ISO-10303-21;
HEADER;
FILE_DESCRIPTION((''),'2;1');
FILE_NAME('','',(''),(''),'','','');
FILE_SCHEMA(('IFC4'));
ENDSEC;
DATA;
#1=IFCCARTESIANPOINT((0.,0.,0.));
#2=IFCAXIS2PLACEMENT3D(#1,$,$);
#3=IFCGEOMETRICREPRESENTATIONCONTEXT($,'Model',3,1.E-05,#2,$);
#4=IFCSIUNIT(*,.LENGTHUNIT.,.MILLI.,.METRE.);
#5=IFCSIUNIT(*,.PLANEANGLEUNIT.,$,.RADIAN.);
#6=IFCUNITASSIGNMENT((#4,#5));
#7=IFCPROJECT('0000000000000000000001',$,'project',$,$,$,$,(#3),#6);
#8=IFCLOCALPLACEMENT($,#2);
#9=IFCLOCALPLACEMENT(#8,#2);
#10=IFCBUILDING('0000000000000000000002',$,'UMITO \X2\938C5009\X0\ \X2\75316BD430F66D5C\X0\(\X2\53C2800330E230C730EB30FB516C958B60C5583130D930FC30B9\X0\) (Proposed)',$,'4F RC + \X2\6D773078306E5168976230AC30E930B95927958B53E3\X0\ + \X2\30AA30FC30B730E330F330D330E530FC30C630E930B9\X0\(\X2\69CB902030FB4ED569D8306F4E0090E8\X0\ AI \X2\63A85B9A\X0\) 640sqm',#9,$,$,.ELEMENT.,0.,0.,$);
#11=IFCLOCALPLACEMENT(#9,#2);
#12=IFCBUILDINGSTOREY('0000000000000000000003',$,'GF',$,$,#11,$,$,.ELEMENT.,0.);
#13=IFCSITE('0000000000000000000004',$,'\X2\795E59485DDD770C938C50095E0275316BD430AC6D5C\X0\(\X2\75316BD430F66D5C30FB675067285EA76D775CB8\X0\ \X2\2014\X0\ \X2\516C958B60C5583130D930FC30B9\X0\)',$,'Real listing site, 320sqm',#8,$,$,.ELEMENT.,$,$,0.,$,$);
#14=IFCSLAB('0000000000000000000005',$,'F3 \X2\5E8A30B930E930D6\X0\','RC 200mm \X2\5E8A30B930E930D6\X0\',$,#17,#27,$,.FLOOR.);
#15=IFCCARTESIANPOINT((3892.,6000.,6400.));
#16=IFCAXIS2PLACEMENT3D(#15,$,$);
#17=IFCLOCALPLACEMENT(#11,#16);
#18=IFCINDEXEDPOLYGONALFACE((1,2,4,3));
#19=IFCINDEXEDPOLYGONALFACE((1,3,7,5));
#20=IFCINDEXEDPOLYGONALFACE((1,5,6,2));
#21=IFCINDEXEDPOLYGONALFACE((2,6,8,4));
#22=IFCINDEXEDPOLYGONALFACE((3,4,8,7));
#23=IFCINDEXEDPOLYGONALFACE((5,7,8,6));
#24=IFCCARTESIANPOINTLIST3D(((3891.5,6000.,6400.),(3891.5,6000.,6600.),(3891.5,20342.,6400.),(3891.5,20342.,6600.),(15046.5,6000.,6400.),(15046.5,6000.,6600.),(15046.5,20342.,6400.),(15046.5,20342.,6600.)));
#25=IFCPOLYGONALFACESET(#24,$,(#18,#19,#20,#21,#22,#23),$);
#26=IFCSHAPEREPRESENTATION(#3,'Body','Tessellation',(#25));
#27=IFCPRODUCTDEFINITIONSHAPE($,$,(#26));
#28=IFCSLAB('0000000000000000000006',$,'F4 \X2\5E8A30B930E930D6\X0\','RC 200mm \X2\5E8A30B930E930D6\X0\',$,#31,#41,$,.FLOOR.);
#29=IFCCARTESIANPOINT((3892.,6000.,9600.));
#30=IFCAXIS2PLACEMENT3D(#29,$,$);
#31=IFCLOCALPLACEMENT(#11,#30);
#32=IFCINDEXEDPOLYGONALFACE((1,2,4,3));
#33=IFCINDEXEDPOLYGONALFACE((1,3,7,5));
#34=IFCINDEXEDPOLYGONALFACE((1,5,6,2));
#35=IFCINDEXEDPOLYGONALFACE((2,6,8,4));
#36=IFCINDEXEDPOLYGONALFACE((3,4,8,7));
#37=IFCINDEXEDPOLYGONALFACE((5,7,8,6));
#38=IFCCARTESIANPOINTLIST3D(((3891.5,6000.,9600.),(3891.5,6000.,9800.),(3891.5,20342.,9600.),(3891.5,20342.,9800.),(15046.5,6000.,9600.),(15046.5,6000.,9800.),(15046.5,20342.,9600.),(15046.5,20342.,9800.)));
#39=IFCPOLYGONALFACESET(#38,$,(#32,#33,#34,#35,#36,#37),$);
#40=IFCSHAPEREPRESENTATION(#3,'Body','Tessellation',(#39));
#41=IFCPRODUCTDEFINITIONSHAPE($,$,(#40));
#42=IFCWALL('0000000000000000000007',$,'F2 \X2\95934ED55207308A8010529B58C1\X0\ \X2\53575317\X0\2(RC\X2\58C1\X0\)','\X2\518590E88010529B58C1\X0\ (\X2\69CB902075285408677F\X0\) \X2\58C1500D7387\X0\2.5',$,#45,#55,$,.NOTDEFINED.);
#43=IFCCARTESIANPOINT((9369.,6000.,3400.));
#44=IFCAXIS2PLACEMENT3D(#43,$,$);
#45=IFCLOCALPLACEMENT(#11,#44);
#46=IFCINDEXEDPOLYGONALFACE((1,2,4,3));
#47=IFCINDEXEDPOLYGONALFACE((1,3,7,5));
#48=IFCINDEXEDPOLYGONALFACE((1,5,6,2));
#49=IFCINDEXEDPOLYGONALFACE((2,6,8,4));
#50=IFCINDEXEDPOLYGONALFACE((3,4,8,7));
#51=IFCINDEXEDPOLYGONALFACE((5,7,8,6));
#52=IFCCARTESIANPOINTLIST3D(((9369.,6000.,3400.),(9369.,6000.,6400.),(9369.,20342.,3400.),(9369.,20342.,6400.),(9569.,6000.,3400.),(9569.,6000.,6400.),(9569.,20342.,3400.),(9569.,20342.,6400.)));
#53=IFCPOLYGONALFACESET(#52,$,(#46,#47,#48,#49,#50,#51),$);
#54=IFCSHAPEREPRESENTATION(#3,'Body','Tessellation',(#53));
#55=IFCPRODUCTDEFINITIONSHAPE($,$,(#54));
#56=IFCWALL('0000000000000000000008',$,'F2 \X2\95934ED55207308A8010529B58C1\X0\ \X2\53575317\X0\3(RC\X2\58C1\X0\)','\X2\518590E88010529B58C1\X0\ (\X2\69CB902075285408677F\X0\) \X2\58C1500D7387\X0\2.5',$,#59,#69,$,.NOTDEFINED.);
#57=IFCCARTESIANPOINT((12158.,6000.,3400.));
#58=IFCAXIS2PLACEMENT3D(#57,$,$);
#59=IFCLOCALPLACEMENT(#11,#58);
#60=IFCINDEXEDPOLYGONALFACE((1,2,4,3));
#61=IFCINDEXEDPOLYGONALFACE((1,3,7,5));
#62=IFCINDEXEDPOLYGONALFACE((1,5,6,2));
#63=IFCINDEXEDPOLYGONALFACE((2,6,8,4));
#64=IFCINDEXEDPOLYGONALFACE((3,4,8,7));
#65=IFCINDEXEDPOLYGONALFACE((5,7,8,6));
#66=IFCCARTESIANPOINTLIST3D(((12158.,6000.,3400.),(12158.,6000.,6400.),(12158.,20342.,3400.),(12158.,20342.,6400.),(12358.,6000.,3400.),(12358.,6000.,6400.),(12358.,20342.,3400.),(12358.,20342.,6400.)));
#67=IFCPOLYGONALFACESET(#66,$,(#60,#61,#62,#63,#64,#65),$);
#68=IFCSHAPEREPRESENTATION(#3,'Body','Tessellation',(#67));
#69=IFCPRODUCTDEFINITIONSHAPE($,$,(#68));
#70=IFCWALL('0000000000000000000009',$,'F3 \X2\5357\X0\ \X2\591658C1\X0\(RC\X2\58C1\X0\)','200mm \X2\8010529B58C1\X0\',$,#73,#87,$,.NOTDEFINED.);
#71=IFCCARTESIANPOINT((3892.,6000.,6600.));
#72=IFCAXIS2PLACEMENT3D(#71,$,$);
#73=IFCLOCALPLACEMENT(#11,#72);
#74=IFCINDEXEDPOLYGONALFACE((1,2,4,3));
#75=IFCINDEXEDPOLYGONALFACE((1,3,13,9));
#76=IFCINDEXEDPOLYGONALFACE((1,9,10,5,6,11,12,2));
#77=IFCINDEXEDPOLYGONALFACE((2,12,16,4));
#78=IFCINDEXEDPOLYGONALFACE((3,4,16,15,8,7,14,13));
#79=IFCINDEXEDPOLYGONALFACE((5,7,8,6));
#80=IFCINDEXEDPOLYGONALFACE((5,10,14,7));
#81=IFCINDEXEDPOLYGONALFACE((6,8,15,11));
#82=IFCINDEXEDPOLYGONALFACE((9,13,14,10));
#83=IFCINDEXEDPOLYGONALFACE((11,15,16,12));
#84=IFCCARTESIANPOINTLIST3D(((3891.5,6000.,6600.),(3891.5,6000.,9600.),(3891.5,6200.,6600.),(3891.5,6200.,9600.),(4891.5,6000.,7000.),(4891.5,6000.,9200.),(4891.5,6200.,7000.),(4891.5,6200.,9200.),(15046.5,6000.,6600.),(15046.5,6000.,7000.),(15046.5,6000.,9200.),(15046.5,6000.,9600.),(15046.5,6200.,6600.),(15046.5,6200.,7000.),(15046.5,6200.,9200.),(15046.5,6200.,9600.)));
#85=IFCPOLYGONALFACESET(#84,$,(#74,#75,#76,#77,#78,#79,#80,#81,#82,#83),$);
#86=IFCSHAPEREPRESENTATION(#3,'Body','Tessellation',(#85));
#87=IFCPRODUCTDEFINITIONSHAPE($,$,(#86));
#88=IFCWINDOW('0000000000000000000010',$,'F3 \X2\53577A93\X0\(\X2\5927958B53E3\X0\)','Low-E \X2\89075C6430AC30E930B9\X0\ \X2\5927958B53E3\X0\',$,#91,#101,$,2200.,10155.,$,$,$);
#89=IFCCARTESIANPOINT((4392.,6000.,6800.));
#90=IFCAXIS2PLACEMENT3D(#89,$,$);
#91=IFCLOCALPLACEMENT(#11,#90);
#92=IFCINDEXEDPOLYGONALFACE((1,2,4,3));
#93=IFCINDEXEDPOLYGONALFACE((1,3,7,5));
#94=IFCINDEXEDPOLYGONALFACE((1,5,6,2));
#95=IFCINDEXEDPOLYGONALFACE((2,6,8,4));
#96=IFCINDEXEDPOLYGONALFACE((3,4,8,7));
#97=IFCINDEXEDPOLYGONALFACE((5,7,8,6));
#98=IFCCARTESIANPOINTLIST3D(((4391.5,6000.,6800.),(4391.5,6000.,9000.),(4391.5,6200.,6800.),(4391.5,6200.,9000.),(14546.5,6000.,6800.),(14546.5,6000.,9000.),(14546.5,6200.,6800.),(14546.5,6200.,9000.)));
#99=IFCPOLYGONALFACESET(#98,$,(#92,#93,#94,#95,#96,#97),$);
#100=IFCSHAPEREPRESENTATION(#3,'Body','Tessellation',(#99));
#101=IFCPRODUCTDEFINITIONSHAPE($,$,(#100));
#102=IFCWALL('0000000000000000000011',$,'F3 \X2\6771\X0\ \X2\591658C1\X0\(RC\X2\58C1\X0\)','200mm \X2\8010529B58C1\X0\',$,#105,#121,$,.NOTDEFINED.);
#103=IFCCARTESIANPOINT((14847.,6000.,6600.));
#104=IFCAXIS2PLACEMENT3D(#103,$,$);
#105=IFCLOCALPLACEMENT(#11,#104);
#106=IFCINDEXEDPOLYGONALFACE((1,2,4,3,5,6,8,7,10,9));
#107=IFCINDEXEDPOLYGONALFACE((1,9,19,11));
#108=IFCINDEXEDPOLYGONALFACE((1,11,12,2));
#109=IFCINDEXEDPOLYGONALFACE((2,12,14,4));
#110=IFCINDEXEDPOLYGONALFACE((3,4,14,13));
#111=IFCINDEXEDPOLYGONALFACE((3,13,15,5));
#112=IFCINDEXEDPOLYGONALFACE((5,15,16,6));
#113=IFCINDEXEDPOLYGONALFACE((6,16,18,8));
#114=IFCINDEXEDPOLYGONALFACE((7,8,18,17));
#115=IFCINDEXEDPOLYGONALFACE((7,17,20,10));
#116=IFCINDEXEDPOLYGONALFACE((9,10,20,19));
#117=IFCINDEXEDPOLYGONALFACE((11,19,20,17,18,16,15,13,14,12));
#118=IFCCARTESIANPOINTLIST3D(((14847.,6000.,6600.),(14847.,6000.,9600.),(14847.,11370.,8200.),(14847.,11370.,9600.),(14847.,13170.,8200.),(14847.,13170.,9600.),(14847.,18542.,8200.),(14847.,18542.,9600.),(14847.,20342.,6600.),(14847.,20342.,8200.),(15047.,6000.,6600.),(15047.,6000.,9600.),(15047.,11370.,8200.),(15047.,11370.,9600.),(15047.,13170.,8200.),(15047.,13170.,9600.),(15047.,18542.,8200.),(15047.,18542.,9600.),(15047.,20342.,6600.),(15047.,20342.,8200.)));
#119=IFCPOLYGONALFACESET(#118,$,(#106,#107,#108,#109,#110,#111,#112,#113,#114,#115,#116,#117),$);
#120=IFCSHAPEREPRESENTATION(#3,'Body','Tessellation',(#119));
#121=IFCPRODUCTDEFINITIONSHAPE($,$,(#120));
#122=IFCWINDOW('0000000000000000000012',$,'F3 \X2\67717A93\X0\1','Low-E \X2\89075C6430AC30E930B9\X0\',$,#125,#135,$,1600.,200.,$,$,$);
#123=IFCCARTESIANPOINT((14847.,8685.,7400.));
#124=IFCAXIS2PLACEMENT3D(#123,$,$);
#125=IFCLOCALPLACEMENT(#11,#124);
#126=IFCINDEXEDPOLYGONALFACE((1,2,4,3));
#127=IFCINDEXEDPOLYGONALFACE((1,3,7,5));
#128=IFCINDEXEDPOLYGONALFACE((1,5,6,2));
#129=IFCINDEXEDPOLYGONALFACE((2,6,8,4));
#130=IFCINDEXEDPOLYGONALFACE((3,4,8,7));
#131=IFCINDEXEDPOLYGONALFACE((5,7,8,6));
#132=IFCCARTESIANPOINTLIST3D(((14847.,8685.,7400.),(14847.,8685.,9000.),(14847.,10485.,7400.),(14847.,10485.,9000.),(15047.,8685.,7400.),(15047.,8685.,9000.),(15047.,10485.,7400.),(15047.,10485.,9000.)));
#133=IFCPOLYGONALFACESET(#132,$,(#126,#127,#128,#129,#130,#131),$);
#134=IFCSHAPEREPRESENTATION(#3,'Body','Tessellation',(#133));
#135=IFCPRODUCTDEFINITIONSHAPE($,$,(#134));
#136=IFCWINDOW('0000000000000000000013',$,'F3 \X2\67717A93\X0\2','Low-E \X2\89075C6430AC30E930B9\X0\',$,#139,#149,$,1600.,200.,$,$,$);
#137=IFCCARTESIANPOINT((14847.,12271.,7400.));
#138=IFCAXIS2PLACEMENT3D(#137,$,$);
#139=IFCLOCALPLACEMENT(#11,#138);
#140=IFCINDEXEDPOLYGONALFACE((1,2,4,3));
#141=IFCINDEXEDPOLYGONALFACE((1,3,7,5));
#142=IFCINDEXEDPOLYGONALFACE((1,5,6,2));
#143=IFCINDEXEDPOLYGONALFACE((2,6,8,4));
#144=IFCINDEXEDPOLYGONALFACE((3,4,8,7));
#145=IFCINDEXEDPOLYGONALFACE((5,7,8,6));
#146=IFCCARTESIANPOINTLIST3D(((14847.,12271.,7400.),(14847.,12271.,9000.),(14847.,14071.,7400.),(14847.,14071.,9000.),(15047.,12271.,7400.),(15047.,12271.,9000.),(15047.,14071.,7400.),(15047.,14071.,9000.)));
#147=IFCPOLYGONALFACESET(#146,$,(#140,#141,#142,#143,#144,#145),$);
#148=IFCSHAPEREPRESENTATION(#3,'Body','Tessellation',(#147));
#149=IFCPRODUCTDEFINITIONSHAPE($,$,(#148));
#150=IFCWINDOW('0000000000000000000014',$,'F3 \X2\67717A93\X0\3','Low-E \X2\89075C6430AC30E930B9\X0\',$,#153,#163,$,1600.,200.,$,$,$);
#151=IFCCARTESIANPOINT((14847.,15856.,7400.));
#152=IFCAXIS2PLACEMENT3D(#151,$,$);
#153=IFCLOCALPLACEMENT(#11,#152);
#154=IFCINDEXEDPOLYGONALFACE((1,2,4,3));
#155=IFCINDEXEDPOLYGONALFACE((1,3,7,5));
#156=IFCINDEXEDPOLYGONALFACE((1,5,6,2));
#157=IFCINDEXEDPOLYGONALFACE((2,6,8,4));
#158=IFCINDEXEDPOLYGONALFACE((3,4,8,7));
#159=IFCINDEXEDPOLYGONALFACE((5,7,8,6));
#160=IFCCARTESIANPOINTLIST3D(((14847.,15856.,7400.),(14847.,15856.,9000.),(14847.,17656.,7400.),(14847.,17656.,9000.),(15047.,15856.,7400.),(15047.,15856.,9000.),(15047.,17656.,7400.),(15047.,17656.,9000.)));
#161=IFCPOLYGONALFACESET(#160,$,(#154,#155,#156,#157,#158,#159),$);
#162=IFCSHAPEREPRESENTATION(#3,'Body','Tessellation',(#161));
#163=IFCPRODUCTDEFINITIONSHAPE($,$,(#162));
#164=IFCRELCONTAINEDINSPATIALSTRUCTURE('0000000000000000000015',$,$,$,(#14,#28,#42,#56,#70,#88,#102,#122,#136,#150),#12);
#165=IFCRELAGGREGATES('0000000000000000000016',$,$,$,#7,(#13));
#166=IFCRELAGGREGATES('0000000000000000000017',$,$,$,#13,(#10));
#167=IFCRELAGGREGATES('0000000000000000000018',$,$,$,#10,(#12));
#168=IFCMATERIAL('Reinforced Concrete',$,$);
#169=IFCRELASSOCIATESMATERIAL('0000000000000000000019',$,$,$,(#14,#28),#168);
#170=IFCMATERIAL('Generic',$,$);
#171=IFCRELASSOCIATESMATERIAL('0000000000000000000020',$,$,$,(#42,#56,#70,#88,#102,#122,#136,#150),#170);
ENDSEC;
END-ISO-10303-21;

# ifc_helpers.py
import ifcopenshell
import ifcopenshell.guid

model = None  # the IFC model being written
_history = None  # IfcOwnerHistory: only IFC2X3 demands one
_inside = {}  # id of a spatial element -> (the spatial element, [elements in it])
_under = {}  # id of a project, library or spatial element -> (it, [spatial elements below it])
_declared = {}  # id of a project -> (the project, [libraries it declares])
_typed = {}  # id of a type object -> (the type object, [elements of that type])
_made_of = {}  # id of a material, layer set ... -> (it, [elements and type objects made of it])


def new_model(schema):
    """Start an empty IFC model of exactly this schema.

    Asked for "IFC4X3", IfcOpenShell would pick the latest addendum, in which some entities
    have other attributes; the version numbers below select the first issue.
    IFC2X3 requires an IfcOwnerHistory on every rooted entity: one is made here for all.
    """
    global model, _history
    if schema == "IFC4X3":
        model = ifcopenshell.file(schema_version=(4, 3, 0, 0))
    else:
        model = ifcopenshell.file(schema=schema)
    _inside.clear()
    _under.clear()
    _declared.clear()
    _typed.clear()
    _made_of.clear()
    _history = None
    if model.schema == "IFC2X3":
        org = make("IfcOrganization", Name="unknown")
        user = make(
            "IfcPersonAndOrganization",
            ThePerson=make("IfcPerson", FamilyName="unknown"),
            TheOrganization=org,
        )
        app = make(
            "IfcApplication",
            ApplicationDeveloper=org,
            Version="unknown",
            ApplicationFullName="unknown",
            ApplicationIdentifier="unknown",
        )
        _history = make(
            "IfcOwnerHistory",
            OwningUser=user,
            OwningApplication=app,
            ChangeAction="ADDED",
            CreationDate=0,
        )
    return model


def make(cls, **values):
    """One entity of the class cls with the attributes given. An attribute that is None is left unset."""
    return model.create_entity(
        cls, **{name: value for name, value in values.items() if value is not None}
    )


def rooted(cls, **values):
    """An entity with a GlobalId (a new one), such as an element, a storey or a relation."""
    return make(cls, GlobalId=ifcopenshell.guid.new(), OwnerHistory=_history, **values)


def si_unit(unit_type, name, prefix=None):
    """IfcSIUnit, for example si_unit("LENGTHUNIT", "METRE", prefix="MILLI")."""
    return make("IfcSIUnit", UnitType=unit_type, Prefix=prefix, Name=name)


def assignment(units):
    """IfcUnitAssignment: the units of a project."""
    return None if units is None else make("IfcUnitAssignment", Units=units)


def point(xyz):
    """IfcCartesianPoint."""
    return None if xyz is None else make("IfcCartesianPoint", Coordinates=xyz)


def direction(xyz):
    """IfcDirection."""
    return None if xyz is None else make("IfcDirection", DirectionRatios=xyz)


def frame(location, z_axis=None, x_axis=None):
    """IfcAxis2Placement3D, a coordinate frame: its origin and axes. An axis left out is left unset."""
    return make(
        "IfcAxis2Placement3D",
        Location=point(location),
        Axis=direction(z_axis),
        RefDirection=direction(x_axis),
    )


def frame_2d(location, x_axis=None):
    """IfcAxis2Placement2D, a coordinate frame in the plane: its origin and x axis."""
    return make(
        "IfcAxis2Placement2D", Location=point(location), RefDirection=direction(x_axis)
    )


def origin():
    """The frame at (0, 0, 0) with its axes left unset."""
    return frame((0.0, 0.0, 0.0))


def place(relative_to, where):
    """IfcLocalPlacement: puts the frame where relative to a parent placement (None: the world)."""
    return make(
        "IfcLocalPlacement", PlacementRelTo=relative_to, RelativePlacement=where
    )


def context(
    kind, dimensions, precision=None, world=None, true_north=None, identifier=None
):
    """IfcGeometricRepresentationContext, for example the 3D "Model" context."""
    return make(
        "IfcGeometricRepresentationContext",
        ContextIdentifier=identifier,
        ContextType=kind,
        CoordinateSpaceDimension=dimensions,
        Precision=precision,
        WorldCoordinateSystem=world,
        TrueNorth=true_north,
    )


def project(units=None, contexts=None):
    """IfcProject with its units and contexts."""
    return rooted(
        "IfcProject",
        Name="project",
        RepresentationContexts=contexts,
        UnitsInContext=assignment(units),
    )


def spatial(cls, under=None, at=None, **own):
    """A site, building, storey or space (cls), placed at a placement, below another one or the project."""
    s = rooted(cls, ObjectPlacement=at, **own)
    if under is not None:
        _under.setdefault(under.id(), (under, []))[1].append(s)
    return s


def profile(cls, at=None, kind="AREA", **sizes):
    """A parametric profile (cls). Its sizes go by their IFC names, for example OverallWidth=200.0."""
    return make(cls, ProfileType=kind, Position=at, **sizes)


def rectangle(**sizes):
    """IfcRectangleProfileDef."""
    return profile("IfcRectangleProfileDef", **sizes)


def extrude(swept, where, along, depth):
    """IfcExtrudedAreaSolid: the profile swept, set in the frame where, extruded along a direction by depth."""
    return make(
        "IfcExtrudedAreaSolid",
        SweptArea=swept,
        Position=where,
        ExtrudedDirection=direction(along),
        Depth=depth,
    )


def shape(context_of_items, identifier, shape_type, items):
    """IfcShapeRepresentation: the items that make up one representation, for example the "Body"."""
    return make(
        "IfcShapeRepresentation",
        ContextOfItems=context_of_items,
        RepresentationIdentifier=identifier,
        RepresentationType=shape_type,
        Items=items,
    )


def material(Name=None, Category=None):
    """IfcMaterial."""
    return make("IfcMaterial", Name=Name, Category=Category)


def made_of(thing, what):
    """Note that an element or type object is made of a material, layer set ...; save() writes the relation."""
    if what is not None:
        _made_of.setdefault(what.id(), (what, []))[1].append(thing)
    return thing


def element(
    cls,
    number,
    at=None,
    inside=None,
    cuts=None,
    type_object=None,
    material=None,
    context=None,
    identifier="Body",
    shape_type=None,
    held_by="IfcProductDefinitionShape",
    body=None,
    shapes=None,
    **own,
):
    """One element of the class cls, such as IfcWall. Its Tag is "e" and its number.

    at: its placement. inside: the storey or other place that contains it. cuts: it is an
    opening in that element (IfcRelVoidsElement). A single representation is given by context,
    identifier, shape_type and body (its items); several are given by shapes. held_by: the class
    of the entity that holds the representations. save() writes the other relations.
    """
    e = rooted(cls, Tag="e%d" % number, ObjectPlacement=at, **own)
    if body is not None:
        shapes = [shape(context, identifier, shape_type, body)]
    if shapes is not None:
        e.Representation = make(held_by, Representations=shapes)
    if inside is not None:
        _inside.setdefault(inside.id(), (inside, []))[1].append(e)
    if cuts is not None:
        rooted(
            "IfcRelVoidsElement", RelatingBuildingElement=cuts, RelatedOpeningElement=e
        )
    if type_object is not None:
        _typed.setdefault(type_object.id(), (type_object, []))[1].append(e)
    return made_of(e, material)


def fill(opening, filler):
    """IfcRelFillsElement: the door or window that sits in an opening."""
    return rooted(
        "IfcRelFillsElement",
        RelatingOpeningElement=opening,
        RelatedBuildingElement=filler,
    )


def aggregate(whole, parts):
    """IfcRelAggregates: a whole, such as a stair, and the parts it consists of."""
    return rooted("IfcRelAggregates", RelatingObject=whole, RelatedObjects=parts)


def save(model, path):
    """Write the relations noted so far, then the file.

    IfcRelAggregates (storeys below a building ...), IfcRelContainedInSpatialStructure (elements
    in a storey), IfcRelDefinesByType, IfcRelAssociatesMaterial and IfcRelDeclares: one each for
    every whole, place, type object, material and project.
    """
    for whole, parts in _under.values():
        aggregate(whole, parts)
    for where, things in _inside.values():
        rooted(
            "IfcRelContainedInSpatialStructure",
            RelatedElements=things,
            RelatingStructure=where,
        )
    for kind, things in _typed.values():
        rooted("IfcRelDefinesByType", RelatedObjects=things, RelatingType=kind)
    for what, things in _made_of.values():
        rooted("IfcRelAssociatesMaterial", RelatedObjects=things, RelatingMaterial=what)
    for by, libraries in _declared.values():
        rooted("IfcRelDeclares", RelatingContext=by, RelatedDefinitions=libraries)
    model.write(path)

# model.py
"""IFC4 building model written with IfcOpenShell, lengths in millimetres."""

from ifc_helpers import new_model, si_unit, frame, frame_2d, origin, place, context, project, spatial, rectangle, extrude, material, element, fill, save


model = new_model("IFC4")

# Units and contexts
model_context = context("Model", 3, precision=1e-05, world=origin())
ifc_project = project(units=[si_unit("LENGTHUNIT", "METRE", prefix="MILLI"), si_unit("PLANEANGLEUNIT", "RADIAN")], contexts=[model_context])

# Site, building, storey
site_placement = place(None, origin())
site = spatial("IfcSite", under=ifc_project, at=site_placement, Name="神奈川県鎌倉市由比ガ浜(由比ヶ浜・材木座海岸 — 公開情報ベース)", ObjectType="Real listing site, 320sqm", CompositionType="ELEMENT", RefElevation=0.0)
building_placement = place(site_placement, origin())
building = spatial("IfcBuilding", under=site, at=building_placement, Name="UMITO 鎌倉 由比ヶ浜(参考モデル・公開情報ベース) (Proposed)", ObjectType="4F RC + 海への全面ガラス大開口 + オーシャンビューテラス(構造・仕様は一部 AI 推定) 640sqm", CompositionType="ELEMENT", ElevationOfRefHeight=0.0, ElevationOfTerrain=0.0)
storey_placement = place(building_placement, origin())
storey = spatial("IfcBuildingStorey", under=building, at=storey_placement, Name="GF", CompositionType="ELEMENT", Elevation=0.0)

# Slabs
ifc_material_1 = material(Name="Reinforced Concrete")
slab_1_placement = place(storey_placement, frame((3892.0, 6000.0, 6400.0)))
element("IfcSlab", 1, at=slab_1_placement, inside=storey, material=ifc_material_1, Name="F3 床スラブ", Description="RC 200mm 床スラブ", PredefinedType="FLOOR", context=model_context, shape_type="SweptSolid", body=[
    extrude(rectangle(XDim=11155.0, YDim=14342.0, at=frame_2d((5577.0, 7171.0))), frame((3892.0, 6000.0, 6400.0)), (0.0, 0.0, 1.0), 200.0),
])
slab_2_placement = place(storey_placement, frame((3892.0, 6000.0, 9600.0)))
element("IfcSlab", 2, at=slab_2_placement, inside=storey, material=ifc_material_1, Name="F4 床スラブ", Description="RC 200mm 床スラブ", PredefinedType="FLOOR", context=model_context, shape_type="SweptSolid", body=[
    extrude(rectangle(XDim=11155.0, YDim=14342.0, at=frame_2d((5577.0, 7171.0))), frame((3892.0, 6000.0, 9600.0)), (0.0, 0.0, 1.0), 200.0),
])

# Walls
ifc_material_2 = material(Name="Generic")
wall_1_placement = place(storey_placement, frame((9369.0, 6000.0, 3400.0)))
element("IfcWall", 3, at=wall_1_placement, inside=storey, material=ifc_material_2, Name="F2 間仕切り耐力壁 南北2(RC壁)", Description="内部耐力壁 (構造用合板) 壁倍率2.5", PredefinedType="NOTDEFINED", context=model_context, shape_type="SweptSolid", body=[
    extrude(rectangle(XDim=200.0, YDim=14342.0, at=frame_2d((100.0, 7171.0))), frame((9369.0, 6000.0, 3400.0)), (0.0, 0.0, 1.0), 3000.0),
])
wall_2_placement = place(storey_placement, frame((12158.0, 6000.0, 3400.0)))
element("IfcWall", 4, at=wall_2_placement, inside=storey, material=ifc_material_2, Name="F2 間仕切り耐力壁 南北3(RC壁)", Description="内部耐力壁 (構造用合板) 壁倍率2.5", PredefinedType="NOTDEFINED", context=model_context, shape_type="SweptSolid", body=[
    extrude(rectangle(XDim=200.0, YDim=14342.0, at=frame_2d((100.0, 7171.0))), frame((12158.0, 6000.0, 3400.0)), (0.0, 0.0, 1.0), 3000.0),
])

# Wall, opening, window
wall_3_placement = place(storey_placement, frame((3892.0, 6000.0, 6600.0)))
wall_3 = element("IfcWall", 5, at=wall_3_placement, inside=storey, material=ifc_material_2, Name="F3 南 外壁(RC壁)", Description="200mm 耐力壁", PredefinedType="NOTDEFINED", context=model_context, shape_type="SweptSolid", body=[
    extrude(rectangle(XDim=11155.0, YDim=200.0, at=frame_2d((5577.0, 100.0))), frame((3892.0, 6000.0, 6600.0)), (0.0, 0.0, 1.0), 3000.0),
])
opening_1_placement = place(storey_placement, frame((4392.0, 6000.0, 6800.0)))
opening_1 = element("IfcOpeningElement", 6, at=opening_1_placement, cuts=wall_3, PredefinedType="NOTDEFINED", context=model_context, shape_type="SweptSolid", body=[
    extrude(rectangle(XDim=10155.0, YDim=200.0, at=frame_2d((5077.0, 100.0))), frame((4392.0, 6000.0, 6800.0)), (0.0, 0.0, 1.0), 2200.0),
])
window_1_placement = place(storey_placement, frame((4392.0, 6000.0, 6800.0)))
window_1 = element("IfcWindow", 7, at=window_1_placement, inside=storey, material=ifc_material_2, Name="F3 南窓(大開口)", Description="Low-E 複層ガラス 大開口", OverallHeight=2200.0, OverallWidth=10155.0, context=model_context, shape_type="SweptSolid", body=[
    extrude(rectangle(XDim=10155.0, YDim=200.0, at=frame_2d((5077.0, 100.0))), frame((4392.0, 6000.0, 6800.0)), (0.0, 0.0, 1.0), 2200.0),
])
fill(opening_1, window_1)

# Wall, openings, windows
wall_4_placement = place(storey_placement, frame((14847.0, 6000.0, 6600.0)))
wall_4 = element("IfcWall", 8, at=wall_4_placement, inside=storey, material=ifc_material_2, Name="F3 東 外壁(RC壁)", Description="200mm 耐力壁", PredefinedType="NOTDEFINED", context=model_context, shape_type="SweptSolid", body=[
    extrude(rectangle(XDim=200.0, YDim=14342.0, at=frame_2d((100.0, 7171.0))), frame((14847.0, 6000.0, 6600.0)), (0.0, 0.0, 1.0), 3000.0),
])
opening_2_placement = place(storey_placement, frame((14847.0, 8685.0, 7400.0)))
opening_2 = element("IfcOpeningElement", 9, at=opening_2_placement, cuts=wall_4, PredefinedType="NOTDEFINED", context=model_context, shape_type="SweptSolid", body=[
    extrude(rectangle(XDim=200.0, YDim=1800.0, at=frame_2d((100.0, 900.0))), frame((14847.0, 8685.0, 7400.0)), (0.0, 0.0, 1.0), 1600.0),
])
opening_3_placement = place(storey_placement, frame((14847.0, 12271.0, 7400.0)))
opening_3 = element("IfcOpeningElement", 10, at=opening_3_placement, cuts=wall_4, PredefinedType="NOTDEFINED", context=model_context, shape_type="SweptSolid", body=[
    extrude(rectangle(XDim=200.0, YDim=1800.0, at=frame_2d((100.0, 900.0))), frame((14847.0, 12271.0, 7400.0)), (0.0, 0.0, 1.0), 1600.0),
])
opening_4_placement = place(storey_placement, frame((14847.0, 15856.0, 7400.0)))
opening_4 = element("IfcOpeningElement", 11, at=opening_4_placement, cuts=wall_4, PredefinedType="NOTDEFINED", context=model_context, shape_type="SweptSolid", body=[
    extrude(rectangle(XDim=200.0, YDim=1800.0, at=frame_2d((100.0, 900.0))), frame((14847.0, 15856.0, 7400.0)), (0.0, 0.0, 1.0), 1600.0),
])
window_2_placement = place(storey_placement, frame((14847.0, 8685.0, 7400.0)))
window_2 = element("IfcWindow", 12, at=window_2_placement, inside=storey, material=ifc_material_2, Name="F3 東窓1", Description="Low-E 複層ガラス", OverallHeight=1600.0, OverallWidth=200.0, context=model_context, shape_type="SweptSolid", body=[
    extrude(rectangle(XDim=200.0, YDim=1800.0, at=frame_2d((100.0, 900.0))), frame((14847.0, 8685.0, 7400.0)), (0.0, 0.0, 1.0), 1600.0),
])
fill(opening_2, window_2)
window_3_placement = place(storey_placement, frame((14847.0, 12271.0, 7400.0)))
window_3 = element("IfcWindow", 13, at=window_3_placement, inside=storey, material=ifc_material_2, Name="F3 東窓2", Description="Low-E 複層ガラス", OverallHeight=1600.0, OverallWidth=200.0, context=model_context, shape_type="SweptSolid", body=[
    extrude(rectangle(XDim=200.0, YDim=1800.0, at=frame_2d((100.0, 900.0))), frame((14847.0, 12271.0, 7400.0)), (0.0, 0.0, 1.0), 1600.0),
])
fill(opening_3, window_3)
window_4_placement = place(storey_placement, frame((14847.0, 15856.0, 7400.0)))
window_4 = element("IfcWindow", 14, at=window_4_placement, inside=storey, material=ifc_material_2, Name="F3 東窓3", Description="Low-E 複層ガラス", OverallHeight=1600.0, OverallWidth=200.0, context=model_context, shape_type="SweptSolid", body=[
    extrude(rectangle(XDim=200.0, YDim=1800.0, at=frame_2d((100.0, 900.0))), frame((14847.0, 15856.0, 7400.0)), (0.0, 0.0, 1.0), 1600.0),
])
fill(opening_4, window_4)

save(model, "model.ifc")
